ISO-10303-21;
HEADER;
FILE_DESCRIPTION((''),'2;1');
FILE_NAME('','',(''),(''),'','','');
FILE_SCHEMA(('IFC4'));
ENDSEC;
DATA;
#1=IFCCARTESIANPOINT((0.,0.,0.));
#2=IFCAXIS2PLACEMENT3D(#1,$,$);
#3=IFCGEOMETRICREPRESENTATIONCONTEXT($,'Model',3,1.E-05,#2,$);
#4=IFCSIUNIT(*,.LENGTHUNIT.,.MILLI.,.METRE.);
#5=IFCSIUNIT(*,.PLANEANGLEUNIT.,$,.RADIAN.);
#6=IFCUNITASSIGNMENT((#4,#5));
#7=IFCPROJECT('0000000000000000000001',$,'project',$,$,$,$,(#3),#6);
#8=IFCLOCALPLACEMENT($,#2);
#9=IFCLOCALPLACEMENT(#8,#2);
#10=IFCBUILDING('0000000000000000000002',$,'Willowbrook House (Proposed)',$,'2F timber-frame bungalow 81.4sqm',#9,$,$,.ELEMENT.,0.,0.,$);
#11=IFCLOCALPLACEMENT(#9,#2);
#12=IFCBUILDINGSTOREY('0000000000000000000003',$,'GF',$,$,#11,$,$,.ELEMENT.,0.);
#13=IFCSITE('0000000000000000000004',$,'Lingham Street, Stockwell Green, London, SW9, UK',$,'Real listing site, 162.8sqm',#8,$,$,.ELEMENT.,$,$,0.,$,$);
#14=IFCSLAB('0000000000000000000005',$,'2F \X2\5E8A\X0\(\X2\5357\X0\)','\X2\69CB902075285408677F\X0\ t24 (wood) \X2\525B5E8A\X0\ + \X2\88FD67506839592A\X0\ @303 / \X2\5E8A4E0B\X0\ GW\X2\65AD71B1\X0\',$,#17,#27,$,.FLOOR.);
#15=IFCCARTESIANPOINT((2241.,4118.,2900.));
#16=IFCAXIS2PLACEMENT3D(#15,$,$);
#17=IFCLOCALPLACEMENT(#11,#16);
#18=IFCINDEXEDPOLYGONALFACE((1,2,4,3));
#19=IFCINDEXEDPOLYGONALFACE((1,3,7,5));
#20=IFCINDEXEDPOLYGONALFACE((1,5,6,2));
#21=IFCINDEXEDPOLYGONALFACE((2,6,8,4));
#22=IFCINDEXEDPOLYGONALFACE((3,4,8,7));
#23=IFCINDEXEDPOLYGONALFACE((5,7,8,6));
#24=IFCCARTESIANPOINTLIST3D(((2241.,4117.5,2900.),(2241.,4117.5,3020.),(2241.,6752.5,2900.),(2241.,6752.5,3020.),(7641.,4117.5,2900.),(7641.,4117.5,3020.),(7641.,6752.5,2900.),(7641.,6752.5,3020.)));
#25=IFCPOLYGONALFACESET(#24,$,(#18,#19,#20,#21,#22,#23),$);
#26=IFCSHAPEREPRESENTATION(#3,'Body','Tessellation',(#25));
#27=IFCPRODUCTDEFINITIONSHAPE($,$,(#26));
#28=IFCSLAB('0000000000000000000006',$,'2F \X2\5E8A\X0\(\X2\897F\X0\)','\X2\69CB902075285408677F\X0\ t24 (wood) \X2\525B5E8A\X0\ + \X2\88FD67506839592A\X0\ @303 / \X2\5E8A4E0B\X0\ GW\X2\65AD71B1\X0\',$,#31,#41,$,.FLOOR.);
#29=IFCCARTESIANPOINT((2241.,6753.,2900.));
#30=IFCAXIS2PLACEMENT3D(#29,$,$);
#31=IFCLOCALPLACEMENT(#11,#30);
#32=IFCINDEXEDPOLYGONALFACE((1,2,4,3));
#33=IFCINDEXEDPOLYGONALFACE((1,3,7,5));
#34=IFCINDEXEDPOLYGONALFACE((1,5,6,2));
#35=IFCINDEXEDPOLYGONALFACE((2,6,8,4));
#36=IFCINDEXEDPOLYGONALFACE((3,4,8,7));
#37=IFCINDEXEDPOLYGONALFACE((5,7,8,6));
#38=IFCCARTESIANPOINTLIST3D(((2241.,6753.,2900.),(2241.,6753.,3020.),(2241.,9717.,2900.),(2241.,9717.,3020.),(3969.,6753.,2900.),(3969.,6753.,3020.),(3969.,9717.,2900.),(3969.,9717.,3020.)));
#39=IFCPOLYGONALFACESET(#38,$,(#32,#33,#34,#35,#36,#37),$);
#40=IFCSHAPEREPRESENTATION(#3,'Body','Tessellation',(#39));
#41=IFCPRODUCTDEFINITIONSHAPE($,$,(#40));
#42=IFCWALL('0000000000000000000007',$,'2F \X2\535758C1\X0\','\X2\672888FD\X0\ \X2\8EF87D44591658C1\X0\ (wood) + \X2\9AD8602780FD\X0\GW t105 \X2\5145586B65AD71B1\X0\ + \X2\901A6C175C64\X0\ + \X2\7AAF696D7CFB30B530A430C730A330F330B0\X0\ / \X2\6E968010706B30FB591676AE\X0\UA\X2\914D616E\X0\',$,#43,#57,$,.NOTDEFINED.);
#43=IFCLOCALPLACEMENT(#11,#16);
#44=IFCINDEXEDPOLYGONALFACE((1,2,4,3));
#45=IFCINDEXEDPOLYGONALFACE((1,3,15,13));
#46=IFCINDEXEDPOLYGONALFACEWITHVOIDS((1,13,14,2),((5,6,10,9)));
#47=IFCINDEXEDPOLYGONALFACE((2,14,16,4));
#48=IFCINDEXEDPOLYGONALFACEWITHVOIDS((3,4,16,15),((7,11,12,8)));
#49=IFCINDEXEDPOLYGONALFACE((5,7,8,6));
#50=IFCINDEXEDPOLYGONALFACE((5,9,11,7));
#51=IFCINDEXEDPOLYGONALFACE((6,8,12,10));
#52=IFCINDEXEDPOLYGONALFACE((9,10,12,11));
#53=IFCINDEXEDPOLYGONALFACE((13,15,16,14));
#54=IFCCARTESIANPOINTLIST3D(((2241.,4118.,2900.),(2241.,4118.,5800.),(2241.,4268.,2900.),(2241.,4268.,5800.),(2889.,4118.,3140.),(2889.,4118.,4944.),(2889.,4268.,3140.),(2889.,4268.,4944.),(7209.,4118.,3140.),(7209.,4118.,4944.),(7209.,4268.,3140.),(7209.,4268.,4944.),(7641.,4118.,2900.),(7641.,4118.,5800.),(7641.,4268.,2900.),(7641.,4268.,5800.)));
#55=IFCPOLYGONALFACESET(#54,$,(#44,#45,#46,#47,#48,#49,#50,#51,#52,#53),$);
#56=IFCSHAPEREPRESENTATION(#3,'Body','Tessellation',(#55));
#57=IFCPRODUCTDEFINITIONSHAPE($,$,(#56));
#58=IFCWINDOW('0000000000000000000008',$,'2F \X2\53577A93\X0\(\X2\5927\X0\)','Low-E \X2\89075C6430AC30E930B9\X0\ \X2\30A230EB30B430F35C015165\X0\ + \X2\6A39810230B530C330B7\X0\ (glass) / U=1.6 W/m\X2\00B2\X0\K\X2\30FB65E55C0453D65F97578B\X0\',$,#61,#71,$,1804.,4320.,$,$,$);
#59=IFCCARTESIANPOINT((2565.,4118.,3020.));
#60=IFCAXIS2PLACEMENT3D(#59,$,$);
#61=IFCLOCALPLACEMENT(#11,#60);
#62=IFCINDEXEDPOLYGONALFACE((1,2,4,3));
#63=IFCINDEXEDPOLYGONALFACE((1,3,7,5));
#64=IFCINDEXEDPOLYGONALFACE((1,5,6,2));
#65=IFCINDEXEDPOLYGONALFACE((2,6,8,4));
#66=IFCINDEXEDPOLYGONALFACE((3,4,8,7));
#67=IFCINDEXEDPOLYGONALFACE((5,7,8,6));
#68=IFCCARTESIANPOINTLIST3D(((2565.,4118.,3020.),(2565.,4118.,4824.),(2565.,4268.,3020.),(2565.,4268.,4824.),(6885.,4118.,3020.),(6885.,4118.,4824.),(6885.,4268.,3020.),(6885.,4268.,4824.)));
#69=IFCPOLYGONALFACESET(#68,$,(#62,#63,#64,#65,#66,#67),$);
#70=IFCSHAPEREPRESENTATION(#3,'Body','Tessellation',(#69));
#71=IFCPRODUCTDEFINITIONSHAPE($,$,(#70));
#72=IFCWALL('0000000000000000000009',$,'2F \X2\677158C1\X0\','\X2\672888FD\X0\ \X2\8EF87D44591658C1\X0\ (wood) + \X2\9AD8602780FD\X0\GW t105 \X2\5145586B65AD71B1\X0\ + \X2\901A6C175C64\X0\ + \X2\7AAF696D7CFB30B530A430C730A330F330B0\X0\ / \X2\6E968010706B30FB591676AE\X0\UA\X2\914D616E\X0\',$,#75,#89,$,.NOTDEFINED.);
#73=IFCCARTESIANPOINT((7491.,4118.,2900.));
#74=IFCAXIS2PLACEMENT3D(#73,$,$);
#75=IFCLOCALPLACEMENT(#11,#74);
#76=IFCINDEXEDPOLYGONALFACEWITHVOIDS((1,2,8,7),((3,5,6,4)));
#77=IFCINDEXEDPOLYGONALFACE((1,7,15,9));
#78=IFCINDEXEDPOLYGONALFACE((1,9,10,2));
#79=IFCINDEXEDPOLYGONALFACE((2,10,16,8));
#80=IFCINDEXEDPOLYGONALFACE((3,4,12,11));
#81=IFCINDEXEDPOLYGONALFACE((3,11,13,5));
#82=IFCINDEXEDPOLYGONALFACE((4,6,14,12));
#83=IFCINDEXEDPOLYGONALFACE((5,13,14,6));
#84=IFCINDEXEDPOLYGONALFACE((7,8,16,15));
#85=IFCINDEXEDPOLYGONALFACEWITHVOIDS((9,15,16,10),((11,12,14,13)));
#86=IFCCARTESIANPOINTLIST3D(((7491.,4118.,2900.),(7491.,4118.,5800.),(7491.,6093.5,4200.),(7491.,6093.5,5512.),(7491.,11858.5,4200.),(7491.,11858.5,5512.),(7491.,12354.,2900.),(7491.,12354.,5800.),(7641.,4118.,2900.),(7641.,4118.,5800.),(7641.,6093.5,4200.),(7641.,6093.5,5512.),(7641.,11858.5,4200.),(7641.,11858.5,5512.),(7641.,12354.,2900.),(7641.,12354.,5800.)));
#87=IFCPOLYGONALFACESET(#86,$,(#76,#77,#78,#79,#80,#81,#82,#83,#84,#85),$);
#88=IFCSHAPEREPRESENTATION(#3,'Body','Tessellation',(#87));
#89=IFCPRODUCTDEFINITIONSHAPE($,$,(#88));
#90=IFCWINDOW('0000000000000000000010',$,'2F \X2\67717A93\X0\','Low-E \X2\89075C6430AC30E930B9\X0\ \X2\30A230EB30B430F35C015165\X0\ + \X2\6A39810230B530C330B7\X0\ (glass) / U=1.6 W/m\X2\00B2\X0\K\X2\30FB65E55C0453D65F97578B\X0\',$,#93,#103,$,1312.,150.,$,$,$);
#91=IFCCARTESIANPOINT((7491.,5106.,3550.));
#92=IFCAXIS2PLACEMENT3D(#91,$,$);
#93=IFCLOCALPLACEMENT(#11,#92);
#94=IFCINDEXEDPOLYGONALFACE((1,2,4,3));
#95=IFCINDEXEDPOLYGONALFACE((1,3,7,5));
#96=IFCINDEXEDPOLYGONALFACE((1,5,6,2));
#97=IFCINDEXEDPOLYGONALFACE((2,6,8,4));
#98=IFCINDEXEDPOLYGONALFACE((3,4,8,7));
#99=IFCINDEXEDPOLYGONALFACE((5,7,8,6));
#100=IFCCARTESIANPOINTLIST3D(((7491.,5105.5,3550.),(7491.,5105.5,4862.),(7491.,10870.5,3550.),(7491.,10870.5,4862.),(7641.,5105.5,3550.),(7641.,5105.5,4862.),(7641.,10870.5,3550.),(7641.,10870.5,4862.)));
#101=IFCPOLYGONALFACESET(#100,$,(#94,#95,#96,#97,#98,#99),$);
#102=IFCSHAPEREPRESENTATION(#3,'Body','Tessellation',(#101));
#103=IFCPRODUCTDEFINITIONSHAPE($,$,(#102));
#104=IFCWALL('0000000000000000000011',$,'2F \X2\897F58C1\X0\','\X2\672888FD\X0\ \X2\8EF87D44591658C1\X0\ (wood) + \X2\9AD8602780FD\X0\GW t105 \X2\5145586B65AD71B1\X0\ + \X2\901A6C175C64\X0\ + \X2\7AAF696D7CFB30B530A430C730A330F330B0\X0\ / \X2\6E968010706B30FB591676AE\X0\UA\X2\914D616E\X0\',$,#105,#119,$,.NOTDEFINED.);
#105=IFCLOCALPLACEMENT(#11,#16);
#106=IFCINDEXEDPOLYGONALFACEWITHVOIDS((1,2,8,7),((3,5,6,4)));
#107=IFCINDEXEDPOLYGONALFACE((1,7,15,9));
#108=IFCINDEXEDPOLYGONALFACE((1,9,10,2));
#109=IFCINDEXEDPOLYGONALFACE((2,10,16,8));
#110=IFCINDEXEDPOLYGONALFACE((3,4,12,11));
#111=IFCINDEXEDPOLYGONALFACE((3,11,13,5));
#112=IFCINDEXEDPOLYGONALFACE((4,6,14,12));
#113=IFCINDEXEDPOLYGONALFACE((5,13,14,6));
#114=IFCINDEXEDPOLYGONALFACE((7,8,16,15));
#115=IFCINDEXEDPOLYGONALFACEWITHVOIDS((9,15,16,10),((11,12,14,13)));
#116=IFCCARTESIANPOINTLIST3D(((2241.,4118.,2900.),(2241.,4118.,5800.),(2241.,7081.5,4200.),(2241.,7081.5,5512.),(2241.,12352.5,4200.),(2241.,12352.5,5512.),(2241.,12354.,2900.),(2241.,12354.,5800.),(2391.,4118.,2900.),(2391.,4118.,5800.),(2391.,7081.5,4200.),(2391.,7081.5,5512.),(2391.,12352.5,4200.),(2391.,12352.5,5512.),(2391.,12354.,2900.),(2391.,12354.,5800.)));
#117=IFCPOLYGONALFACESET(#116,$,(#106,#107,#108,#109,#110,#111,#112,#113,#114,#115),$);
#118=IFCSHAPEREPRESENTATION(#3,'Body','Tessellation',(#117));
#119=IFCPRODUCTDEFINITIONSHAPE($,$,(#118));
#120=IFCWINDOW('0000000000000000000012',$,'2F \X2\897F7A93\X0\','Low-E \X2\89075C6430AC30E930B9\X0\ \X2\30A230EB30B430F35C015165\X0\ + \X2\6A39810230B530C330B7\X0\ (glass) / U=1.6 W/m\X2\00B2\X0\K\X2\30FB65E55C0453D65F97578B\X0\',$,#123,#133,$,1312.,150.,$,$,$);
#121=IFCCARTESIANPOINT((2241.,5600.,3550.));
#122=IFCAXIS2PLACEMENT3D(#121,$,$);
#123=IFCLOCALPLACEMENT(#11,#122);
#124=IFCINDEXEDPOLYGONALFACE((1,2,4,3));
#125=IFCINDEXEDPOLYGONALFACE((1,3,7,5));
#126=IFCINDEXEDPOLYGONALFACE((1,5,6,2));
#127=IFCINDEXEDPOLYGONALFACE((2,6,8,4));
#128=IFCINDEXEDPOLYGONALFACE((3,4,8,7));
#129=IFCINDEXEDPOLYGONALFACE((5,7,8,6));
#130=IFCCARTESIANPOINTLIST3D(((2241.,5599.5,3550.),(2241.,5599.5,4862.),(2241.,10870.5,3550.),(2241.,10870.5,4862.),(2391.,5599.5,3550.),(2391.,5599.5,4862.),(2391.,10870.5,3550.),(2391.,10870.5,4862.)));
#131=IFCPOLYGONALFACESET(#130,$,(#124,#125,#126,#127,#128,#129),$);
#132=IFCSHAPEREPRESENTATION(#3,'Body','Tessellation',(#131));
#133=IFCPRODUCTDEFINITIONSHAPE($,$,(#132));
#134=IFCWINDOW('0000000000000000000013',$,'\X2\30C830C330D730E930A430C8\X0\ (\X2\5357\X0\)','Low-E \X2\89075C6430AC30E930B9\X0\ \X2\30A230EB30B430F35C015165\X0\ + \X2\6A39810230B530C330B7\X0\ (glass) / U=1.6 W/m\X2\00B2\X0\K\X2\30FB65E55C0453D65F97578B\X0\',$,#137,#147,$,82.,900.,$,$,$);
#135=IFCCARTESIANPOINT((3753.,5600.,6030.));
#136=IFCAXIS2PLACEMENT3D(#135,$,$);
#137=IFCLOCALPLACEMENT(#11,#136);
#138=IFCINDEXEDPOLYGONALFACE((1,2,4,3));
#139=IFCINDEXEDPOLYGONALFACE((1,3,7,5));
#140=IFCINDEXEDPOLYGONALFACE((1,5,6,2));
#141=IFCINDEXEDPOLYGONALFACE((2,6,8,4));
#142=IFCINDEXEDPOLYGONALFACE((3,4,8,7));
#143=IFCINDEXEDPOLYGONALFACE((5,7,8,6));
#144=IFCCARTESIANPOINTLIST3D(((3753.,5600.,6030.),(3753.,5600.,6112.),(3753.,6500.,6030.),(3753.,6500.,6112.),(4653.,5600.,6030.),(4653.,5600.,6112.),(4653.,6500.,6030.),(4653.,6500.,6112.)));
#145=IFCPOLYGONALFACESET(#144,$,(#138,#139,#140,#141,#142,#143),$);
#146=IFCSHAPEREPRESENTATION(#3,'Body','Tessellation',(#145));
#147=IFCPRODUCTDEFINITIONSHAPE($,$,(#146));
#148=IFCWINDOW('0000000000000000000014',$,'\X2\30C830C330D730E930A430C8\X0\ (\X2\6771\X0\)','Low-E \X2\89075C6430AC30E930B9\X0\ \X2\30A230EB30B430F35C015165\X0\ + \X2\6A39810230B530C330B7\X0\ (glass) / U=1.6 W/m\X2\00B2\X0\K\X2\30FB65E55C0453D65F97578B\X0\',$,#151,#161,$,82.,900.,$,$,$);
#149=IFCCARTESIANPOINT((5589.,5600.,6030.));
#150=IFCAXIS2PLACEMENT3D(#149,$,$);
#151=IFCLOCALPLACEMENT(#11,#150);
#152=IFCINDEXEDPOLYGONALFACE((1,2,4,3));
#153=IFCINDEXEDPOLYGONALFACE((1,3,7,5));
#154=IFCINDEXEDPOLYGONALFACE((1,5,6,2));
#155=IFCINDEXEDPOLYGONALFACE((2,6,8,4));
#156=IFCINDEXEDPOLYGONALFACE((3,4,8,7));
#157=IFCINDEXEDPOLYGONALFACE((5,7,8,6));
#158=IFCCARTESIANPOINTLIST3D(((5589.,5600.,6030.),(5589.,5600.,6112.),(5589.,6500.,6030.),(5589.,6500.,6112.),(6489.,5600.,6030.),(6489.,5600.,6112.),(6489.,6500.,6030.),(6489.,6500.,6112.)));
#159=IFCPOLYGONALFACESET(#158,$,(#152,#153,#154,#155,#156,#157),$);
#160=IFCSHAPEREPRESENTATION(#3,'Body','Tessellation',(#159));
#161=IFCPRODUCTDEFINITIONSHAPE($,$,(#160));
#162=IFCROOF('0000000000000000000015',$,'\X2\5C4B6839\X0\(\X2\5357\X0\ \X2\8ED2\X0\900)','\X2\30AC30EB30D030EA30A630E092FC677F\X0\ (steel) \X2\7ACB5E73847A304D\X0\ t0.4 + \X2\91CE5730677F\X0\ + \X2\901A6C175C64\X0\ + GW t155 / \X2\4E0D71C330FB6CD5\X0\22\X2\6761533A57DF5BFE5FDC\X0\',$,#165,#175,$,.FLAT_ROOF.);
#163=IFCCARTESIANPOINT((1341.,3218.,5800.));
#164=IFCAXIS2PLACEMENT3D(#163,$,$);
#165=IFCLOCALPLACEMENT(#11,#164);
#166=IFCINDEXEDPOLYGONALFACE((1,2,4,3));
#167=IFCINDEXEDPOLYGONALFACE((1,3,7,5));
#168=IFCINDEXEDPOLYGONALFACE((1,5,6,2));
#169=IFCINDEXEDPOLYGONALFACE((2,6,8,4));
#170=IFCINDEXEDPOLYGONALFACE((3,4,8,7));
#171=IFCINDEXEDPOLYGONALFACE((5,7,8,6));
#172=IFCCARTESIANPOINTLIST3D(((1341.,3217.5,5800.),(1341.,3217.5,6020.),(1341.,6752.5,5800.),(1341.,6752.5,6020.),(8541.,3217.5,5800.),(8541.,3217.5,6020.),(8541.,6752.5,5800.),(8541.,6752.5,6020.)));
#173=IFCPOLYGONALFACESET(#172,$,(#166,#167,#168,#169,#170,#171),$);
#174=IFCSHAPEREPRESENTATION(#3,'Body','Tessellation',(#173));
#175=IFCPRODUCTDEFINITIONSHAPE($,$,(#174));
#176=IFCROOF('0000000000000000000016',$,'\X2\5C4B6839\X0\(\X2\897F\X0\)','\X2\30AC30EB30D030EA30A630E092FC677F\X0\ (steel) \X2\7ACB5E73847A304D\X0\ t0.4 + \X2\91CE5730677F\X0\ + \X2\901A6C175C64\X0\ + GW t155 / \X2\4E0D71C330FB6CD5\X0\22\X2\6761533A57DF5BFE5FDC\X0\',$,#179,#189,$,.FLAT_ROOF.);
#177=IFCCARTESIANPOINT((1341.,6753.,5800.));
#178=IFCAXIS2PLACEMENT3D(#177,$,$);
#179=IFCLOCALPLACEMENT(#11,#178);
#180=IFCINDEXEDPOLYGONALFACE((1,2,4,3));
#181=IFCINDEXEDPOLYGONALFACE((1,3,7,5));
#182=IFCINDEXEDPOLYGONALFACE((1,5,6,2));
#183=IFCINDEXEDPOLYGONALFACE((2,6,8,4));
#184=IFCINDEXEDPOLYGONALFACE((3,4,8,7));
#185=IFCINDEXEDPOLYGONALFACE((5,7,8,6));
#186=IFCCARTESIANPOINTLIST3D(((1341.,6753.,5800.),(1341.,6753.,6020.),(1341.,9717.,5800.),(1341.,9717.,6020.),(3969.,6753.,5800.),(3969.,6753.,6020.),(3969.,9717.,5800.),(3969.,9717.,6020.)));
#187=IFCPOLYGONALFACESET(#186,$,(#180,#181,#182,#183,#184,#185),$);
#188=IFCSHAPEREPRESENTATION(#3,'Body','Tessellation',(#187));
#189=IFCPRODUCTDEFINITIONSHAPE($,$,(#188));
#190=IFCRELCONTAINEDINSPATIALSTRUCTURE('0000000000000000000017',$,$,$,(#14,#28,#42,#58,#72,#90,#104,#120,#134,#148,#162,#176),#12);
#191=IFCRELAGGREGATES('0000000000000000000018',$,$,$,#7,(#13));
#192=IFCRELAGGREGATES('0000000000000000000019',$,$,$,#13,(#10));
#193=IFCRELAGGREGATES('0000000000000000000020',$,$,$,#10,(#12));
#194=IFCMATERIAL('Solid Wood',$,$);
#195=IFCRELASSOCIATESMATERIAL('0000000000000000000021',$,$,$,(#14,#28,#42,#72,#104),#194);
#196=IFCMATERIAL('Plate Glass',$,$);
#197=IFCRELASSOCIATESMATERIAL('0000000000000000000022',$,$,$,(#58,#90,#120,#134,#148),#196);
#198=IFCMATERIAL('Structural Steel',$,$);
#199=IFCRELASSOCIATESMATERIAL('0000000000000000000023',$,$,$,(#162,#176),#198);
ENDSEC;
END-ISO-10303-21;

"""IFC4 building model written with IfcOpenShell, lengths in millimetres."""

from ifc_helpers import new_model, si_unit, frame, frame_2d, origin, place, context, project, spatial, rectangle, extrude, material, element, fill, save


model = new_model("IFC4")

# Units and contexts
model_context = context("Model", 3, precision=1e-05, world=origin())
ifc_project = project(units=[si_unit("LENGTHUNIT", "METRE", prefix="MILLI"), si_unit("PLANEANGLEUNIT", "RADIAN")], contexts=[model_context])

# Site, building, storey
site_placement = place(None, origin())
site = spatial("IfcSite", under=ifc_project, at=site_placement, Name="Lingham Street, Stockwell Green, London, SW9, UK", ObjectType="Real listing site, 162.8sqm", CompositionType="ELEMENT", RefElevation=0.0)
building_placement = place(site_placement, origin())
building = spatial("IfcBuilding", under=site, at=building_placement, Name="Willowbrook House (Proposed)", ObjectType="2F timber-frame bungalow 81.4sqm", CompositionType="ELEMENT", ElevationOfRefHeight=0.0, ElevationOfTerrain=0.0)
storey_placement = place(building_placement, origin())
storey = spatial("IfcBuildingStorey", under=building, at=storey_placement, Name="GF", CompositionType="ELEMENT", Elevation=0.0)

# Slabs
ifc_material_1 = material(Name="Solid Wood")
slab_1_placement = place(storey_placement, frame((2241.0, 4118.0, 2900.0)))
element("IfcSlab", 1, at=slab_1_placement, inside=storey, material=ifc_material_1, Name="2F 床(南)", Description="構造用合板 t24 (wood) 剛床 + 製材根太 @303 / 床下 GW断熱", PredefinedType="FLOOR", context=model_context, shape_type="SweptSolid", body=[
    extrude(rectangle(XDim=5400.0, YDim=2635.0, at=frame_2d((2700.0, 1317.0))), frame((2241.0, 4118.0, 2900.0)), (0.0, 0.0, 1.0), 120.0),
])
slab_2_placement = place(storey_placement, frame((2241.0, 6753.0, 2900.0)))
element("IfcSlab", 2, at=slab_2_placement, inside=storey, material=ifc_material_1, Name="2F 床(西)", Description="構造用合板 t24 (wood) 剛床 + 製材根太 @303 / 床下 GW断熱", PredefinedType="FLOOR", context=model_context, shape_type="SweptSolid", body=[
    extrude(rectangle(XDim=1728.0, YDim=2964.0, at=frame_2d((864.0, 1482.0))), frame((2241.0, 6753.0, 2900.0)), (0.0, 0.0, 1.0), 120.0),
])

# Walls, openings, windows
wall_1_placement = place(storey_placement, frame((2241.0, 4118.0, 2900.0)))
wall_1 = element("IfcWall", 3, at=wall_1_placement, inside=storey, material=ifc_material_1, Name="2F 南壁", Description="木製 軸組外壁 (wood) + 高性能GW t105 充填断熱 + 通気層 + 窯業系サイディング / 準耐火・外皮UA配慮", PredefinedType="NOTDEFINED", context=model_context, shape_type="SweptSolid", body=[
    extrude(rectangle(XDim=5400.0, YDim=150.0, at=frame_2d((2700.0, 75.0))), frame((2241.0, 4118.0, 2900.0)), (0.0, 0.0, 1.0), 2900.0),
])
opening_1_placement = place(storey_placement, frame((2565.0, 4118.0, 3020.0)))
opening_1 = element("IfcOpeningElement", 4, at=opening_1_placement, cuts=wall_1, PredefinedType="NOTDEFINED", context=model_context, shape_type="SweptSolid", body=[
    extrude(rectangle(XDim=4320.0, YDim=150.0, at=frame_2d((2160.0, 75.0))), frame((2565.0, 4118.0, 3020.0)), (0.0, 0.0, 1.0), 1804.0),
])
ifc_material_2 = material(Name="Plate Glass")
window_1_placement = place(storey_placement, frame((2565.0, 4118.0, 3020.0)))
window_1 = element("IfcWindow", 5, at=window_1_placement, inside=storey, material=ifc_material_2, Name="2F 南窓(大)", Description="Low-E 複層ガラス アルゴン封入 + 樹脂サッシ (glass) / U=1.6 W/m²K・日射取得型", OverallHeight=1804.0, OverallWidth=4320.0, context=model_context, shape_type="SweptSolid", body=[
    extrude(rectangle(XDim=4320.0, YDim=150.0, at=frame_2d((2160.0, 75.0))), frame((2565.0, 4118.0, 3020.0)), (0.0, 0.0, 1.0), 1804.0),
])
fill(opening_1, window_1)
wall_2_placement = place(storey_placement, frame((7491.0, 4118.0, 2900.0)))
wall_2 = element("IfcWall", 6, at=wall_2_placement, inside=storey, material=ifc_material_1, Name="2F 東壁", Description="木製 軸組外壁 (wood) + 高性能GW t105 充填断熱 + 通気層 + 窯業系サイディング / 準耐火・外皮UA配慮", PredefinedType="NOTDEFINED", context=model_context, shape_type="SweptSolid", body=[
    extrude(rectangle(XDim=150.0, YDim=8236.0, at=frame_2d((75.0, 4118.0))), frame((7491.0, 4118.0, 2900.0)), (0.0, 0.0, 1.0), 2900.0),
])
opening_2_placement = place(storey_placement, frame((7491.0, 5106.0, 3550.0)))
opening_2 = element("IfcOpeningElement", 7, at=opening_2_placement, cuts=wall_2, PredefinedType="NOTDEFINED", context=model_context, shape_type="SweptSolid", body=[
    extrude(rectangle(XDim=150.0, YDim=5765.0, at=frame_2d((75.0, 2882.0))), frame((7491.0, 5106.0, 3550.0)), (0.0, 0.0, 1.0), 1312.0),
])
window_2_placement = place(storey_placement, frame((7491.0, 5106.0, 3550.0)))
window_2 = element("IfcWindow", 8, at=window_2_placement, inside=storey, material=ifc_material_2, Name="2F 東窓", Description="Low-E 複層ガラス アルゴン封入 + 樹脂サッシ (glass) / U=1.6 W/m²K・日射取得型", OverallHeight=1312.0, OverallWidth=150.0, context=model_context, shape_type="SweptSolid", body=[
    extrude(rectangle(XDim=150.0, YDim=5765.0, at=frame_2d((75.0, 2882.0))), frame((7491.0, 5106.0, 3550.0)), (0.0, 0.0, 1.0), 1312.0),
])
fill(opening_2, window_2)
wall_3_placement = place(storey_placement, frame((2241.0, 4118.0, 2900.0)))
wall_3 = element("IfcWall", 9, at=wall_3_placement, inside=storey, material=ifc_material_1, Name="2F 西壁", Description="木製 軸組外壁 (wood) + 高性能GW t105 充填断熱 + 通気層 + 窯業系サイディング / 準耐火・外皮UA配慮", PredefinedType="NOTDEFINED", context=model_context, shape_type="SweptSolid", body=[
    extrude(rectangle(XDim=150.0, YDim=8236.0, at=frame_2d((75.0, 4118.0))), frame((2241.0, 4118.0, 2900.0)), (0.0, 0.0, 1.0), 2900.0),
])
opening_3_placement = place(storey_placement, frame((2241.0, 5600.0, 3550.0)))
opening_3 = element("IfcOpeningElement", 10, at=opening_3_placement, cuts=wall_3, PredefinedType="NOTDEFINED", context=model_context, shape_type="SweptSolid", body=[
    extrude(rectangle(XDim=150.0, YDim=5271.0, at=frame_2d((75.0, 2635.0))), frame((2241.0, 5600.0, 3550.0)), (0.0, 0.0, 1.0), 1312.0),
])
window_3_placement = place(storey_placement, frame((2241.0, 5600.0, 3550.0)))
window_3 = element("IfcWindow", 11, at=window_3_placement, inside=storey, material=ifc_material_2, Name="2F 西窓", Description="Low-E 複層ガラス アルゴン封入 + 樹脂サッシ (glass) / U=1.6 W/m²K・日射取得型", OverallHeight=1312.0, OverallWidth=150.0, context=model_context, shape_type="SweptSolid", body=[
    extrude(rectangle(XDim=150.0, YDim=5271.0, at=frame_2d((75.0, 2635.0))), frame((2241.0, 5600.0, 3550.0)), (0.0, 0.0, 1.0), 1312.0),
])
fill(opening_3, window_3)

# Windows
window_4_placement = place(storey_placement, frame((3753.0, 5600.0, 6030.0)))
element("IfcWindow", 12, at=window_4_placement, inside=storey, material=ifc_material_2, Name="トップライト (南)", Description="Low-E 複層ガラス アルゴン封入 + 樹脂サッシ (glass) / U=1.6 W/m²K・日射取得型", OverallHeight=82.0, OverallWidth=900.0, context=model_context, shape_type="SweptSolid", body=[
    extrude(rectangle(XDim=900.0, YDim=900.0, at=frame_2d((450.0, 450.0))), frame((3753.0, 5600.0, 6030.0)), (0.0, 0.0, 1.0), 82.0),
])
window_5_placement = place(storey_placement, frame((5589.0, 5600.0, 6030.0)))
element("IfcWindow", 13, at=window_5_placement, inside=storey, material=ifc_material_2, Name="トップライト (東)", Description="Low-E 複層ガラス アルゴン封入 + 樹脂サッシ (glass) / U=1.6 W/m²K・日射取得型", OverallHeight=82.0, OverallWidth=900.0, context=model_context, shape_type="SweptSolid", body=[
    extrude(rectangle(XDim=900.0, YDim=900.0, at=frame_2d((450.0, 450.0))), frame((5589.0, 5600.0, 6030.0)), (0.0, 0.0, 1.0), 82.0),
])

# Roofs
ifc_material_3 = material(Name="Structural Steel")
roof_1_placement = place(storey_placement, frame((1341.0, 3218.0, 5800.0)))
element("IfcRoof", 14, at=roof_1_placement, inside=storey, material=ifc_material_3, Name="屋根(南 軒900)", Description="ガルバリウム鋼板 (steel) 立平葺き t0.4 + 野地板 + 通気層 + GW t155 / 不燃・法22条区域対応", PredefinedType="FLAT_ROOF", context=model_context, shape_type="SweptSolid", body=[
    extrude(rectangle(XDim=7200.0, YDim=3535.0, at=frame_2d((3600.0, 1767.0))), frame((1341.0, 3218.0, 5800.0)), (0.0, 0.0, 1.0), 220.0),
])
roof_2_placement = place(storey_placement, frame((1341.0, 6753.0, 5800.0)))
element("IfcRoof", 15, at=roof_2_placement, inside=storey, material=ifc_material_3, Name="屋根(西)", Description="ガルバリウム鋼板 (steel) 立平葺き t0.4 + 野地板 + 通気層 + GW t155 / 不燃・法22条区域対応", PredefinedType="FLAT_ROOF", context=model_context, shape_type="SweptSolid", body=[
    extrude(rectangle(XDim=2628.0, YDim=2964.0, at=frame_2d((1314.0, 1482.0))), frame((1341.0, 6753.0, 5800.0)), (0.0, 0.0, 1.0), 220.0),
])

save(model, "model.ifc")
